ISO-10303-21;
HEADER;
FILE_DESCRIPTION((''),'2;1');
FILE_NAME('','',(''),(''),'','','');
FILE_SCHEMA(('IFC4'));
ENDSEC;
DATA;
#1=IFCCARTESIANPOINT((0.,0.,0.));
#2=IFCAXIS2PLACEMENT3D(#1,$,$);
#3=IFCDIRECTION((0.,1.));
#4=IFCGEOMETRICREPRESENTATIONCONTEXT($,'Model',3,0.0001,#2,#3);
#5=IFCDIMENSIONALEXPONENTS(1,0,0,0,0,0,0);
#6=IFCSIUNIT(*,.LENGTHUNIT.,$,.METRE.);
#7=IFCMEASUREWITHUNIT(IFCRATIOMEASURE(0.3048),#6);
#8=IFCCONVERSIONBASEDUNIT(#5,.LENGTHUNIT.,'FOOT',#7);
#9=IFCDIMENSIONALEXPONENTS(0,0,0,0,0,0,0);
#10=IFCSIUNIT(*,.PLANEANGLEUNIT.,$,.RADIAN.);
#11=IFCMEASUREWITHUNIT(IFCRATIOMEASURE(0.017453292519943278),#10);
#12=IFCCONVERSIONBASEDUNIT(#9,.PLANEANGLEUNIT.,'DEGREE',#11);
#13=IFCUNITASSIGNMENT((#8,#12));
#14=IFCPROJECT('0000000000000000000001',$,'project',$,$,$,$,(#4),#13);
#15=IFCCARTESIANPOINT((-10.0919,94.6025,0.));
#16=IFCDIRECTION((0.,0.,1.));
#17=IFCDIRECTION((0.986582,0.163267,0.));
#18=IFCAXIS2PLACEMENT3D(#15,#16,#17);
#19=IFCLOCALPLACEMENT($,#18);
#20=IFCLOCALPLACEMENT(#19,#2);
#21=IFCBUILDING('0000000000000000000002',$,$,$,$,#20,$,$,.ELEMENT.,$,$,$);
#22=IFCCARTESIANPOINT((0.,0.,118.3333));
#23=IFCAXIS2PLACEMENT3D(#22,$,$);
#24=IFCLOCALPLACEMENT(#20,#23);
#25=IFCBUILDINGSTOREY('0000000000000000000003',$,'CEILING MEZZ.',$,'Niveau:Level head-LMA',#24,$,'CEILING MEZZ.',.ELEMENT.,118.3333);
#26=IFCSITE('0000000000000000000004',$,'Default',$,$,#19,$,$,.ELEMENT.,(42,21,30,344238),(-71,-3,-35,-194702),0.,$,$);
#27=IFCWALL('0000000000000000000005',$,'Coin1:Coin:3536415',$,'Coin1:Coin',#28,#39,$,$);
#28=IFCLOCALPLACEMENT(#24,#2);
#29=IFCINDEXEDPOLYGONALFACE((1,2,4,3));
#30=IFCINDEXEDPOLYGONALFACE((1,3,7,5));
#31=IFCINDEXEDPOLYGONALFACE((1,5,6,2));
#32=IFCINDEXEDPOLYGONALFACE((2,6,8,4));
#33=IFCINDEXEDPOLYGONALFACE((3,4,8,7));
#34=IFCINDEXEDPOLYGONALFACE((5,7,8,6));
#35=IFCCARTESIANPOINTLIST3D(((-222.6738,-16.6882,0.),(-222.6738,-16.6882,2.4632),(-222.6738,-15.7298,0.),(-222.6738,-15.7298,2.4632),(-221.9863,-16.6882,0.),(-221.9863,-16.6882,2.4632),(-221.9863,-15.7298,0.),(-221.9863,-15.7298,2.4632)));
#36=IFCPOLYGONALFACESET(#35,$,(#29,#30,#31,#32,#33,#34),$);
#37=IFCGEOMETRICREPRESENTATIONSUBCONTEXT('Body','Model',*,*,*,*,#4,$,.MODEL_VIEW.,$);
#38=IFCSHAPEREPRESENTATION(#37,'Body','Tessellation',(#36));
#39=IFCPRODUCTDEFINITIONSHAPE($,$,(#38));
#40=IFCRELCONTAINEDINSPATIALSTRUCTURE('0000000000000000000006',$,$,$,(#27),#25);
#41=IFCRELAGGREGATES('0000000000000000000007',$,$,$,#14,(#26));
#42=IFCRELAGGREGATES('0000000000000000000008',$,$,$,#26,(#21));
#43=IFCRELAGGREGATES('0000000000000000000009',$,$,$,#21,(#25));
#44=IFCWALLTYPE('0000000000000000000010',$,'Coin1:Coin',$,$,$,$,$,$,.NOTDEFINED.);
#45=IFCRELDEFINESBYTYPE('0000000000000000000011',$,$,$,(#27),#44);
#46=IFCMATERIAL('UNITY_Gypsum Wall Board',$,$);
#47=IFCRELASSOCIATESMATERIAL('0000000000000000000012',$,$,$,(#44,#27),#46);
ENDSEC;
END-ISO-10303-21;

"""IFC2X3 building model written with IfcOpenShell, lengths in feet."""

from ifc_helpers import new_model, entity, si_unit, converted_unit, direction, frame, frame_2d, origin, place, context, subcontext, project, spatial, rectangle, extrude, material, type_object, element, save


model = new_model("IFC2X3")

# Units and contexts
model_context = context("Model", 3, precision=0.0001, world=origin(), true_north=direction((0.0, 1.0)))
body_context = subcontext(model_context, "Body", "Model", "MODEL_VIEW")
ifc_project = project(units=[converted_unit("LENGTHUNIT", "FOOT", entity("IfcRatioMeasure", 0.3048), si_unit("LENGTHUNIT", "METRE"), dimensions=[1, 0, 0, 0, 0, 0, 0]), converted_unit("PLANEANGLEUNIT", "DEGREE", entity("IfcRatioMeasure", 0.017453292519943278), si_unit("PLANEANGLEUNIT", "RADIAN"), dimensions=[0, 0, 0, 0, 0, 0, 0])], contexts=[model_context])

# Site, building, storey
site_placement = place(None, frame((-10.0919, 94.6025, 0.0), z_axis=(0.0, 0.0, 1.0), x_axis=(0.986582, 0.163267, 0.0)))
site = spatial("IfcSite", under=ifc_project, at=site_placement, Name="Default", CompositionType="ELEMENT", RefLatitude=(42, 21, 30, 344238), RefLongitude=(-71, -3, -35, -194702), RefElevation=0.0)
building_placement = place(site_placement, origin())
building = spatial("IfcBuilding", under=site, at=building_placement, CompositionType="ELEMENT")
storey_placement = place(building_placement, frame((0.0, 0.0, 118.3333)))
storey = spatial("IfcBuildingStorey", under=building, at=storey_placement, Name="CEILING MEZZ.", ObjectType="Niveau:Level head-LMA", LongName="CEILING MEZZ.", CompositionType="ELEMENT", Elevation=118.3333)

# Wall
ifc_material = material(Name="UNITY_Gypsum Wall Board")
wall_type = type_object("IfcWallType", Name="Coin1:Coin", PredefinedType="NOTDEFINED", material=ifc_material)
wall_placement = place(storey_placement, frame((-222.6738, -16.6882, 0.0), z_axis=(0.0, 0.0, 1.0), x_axis=(0.0, 1.0, 0.0)))
element("IfcWall", 1, at=wall_placement, inside=storey, type_object=wall_type, material=ifc_material, Name="Coin1:Coin:3536415", ObjectType="Coin1:Coin", context=body_context, shape_type="SweptSolid", body=[
    extrude(rectangle(XDim=0.6875, YDim=0.9583, at=frame_2d((0.0, 0.0), x_axis=(1.0, 0.0))), frame((0.4792, -0.3438, 0.0), z_axis=(0.0, 0.0, 1.0), x_axis=(0.0, 1.0, 0.0)), (0.0, 0.0, 1.0), 2.4632),
])

save(model, "model.ifc")
